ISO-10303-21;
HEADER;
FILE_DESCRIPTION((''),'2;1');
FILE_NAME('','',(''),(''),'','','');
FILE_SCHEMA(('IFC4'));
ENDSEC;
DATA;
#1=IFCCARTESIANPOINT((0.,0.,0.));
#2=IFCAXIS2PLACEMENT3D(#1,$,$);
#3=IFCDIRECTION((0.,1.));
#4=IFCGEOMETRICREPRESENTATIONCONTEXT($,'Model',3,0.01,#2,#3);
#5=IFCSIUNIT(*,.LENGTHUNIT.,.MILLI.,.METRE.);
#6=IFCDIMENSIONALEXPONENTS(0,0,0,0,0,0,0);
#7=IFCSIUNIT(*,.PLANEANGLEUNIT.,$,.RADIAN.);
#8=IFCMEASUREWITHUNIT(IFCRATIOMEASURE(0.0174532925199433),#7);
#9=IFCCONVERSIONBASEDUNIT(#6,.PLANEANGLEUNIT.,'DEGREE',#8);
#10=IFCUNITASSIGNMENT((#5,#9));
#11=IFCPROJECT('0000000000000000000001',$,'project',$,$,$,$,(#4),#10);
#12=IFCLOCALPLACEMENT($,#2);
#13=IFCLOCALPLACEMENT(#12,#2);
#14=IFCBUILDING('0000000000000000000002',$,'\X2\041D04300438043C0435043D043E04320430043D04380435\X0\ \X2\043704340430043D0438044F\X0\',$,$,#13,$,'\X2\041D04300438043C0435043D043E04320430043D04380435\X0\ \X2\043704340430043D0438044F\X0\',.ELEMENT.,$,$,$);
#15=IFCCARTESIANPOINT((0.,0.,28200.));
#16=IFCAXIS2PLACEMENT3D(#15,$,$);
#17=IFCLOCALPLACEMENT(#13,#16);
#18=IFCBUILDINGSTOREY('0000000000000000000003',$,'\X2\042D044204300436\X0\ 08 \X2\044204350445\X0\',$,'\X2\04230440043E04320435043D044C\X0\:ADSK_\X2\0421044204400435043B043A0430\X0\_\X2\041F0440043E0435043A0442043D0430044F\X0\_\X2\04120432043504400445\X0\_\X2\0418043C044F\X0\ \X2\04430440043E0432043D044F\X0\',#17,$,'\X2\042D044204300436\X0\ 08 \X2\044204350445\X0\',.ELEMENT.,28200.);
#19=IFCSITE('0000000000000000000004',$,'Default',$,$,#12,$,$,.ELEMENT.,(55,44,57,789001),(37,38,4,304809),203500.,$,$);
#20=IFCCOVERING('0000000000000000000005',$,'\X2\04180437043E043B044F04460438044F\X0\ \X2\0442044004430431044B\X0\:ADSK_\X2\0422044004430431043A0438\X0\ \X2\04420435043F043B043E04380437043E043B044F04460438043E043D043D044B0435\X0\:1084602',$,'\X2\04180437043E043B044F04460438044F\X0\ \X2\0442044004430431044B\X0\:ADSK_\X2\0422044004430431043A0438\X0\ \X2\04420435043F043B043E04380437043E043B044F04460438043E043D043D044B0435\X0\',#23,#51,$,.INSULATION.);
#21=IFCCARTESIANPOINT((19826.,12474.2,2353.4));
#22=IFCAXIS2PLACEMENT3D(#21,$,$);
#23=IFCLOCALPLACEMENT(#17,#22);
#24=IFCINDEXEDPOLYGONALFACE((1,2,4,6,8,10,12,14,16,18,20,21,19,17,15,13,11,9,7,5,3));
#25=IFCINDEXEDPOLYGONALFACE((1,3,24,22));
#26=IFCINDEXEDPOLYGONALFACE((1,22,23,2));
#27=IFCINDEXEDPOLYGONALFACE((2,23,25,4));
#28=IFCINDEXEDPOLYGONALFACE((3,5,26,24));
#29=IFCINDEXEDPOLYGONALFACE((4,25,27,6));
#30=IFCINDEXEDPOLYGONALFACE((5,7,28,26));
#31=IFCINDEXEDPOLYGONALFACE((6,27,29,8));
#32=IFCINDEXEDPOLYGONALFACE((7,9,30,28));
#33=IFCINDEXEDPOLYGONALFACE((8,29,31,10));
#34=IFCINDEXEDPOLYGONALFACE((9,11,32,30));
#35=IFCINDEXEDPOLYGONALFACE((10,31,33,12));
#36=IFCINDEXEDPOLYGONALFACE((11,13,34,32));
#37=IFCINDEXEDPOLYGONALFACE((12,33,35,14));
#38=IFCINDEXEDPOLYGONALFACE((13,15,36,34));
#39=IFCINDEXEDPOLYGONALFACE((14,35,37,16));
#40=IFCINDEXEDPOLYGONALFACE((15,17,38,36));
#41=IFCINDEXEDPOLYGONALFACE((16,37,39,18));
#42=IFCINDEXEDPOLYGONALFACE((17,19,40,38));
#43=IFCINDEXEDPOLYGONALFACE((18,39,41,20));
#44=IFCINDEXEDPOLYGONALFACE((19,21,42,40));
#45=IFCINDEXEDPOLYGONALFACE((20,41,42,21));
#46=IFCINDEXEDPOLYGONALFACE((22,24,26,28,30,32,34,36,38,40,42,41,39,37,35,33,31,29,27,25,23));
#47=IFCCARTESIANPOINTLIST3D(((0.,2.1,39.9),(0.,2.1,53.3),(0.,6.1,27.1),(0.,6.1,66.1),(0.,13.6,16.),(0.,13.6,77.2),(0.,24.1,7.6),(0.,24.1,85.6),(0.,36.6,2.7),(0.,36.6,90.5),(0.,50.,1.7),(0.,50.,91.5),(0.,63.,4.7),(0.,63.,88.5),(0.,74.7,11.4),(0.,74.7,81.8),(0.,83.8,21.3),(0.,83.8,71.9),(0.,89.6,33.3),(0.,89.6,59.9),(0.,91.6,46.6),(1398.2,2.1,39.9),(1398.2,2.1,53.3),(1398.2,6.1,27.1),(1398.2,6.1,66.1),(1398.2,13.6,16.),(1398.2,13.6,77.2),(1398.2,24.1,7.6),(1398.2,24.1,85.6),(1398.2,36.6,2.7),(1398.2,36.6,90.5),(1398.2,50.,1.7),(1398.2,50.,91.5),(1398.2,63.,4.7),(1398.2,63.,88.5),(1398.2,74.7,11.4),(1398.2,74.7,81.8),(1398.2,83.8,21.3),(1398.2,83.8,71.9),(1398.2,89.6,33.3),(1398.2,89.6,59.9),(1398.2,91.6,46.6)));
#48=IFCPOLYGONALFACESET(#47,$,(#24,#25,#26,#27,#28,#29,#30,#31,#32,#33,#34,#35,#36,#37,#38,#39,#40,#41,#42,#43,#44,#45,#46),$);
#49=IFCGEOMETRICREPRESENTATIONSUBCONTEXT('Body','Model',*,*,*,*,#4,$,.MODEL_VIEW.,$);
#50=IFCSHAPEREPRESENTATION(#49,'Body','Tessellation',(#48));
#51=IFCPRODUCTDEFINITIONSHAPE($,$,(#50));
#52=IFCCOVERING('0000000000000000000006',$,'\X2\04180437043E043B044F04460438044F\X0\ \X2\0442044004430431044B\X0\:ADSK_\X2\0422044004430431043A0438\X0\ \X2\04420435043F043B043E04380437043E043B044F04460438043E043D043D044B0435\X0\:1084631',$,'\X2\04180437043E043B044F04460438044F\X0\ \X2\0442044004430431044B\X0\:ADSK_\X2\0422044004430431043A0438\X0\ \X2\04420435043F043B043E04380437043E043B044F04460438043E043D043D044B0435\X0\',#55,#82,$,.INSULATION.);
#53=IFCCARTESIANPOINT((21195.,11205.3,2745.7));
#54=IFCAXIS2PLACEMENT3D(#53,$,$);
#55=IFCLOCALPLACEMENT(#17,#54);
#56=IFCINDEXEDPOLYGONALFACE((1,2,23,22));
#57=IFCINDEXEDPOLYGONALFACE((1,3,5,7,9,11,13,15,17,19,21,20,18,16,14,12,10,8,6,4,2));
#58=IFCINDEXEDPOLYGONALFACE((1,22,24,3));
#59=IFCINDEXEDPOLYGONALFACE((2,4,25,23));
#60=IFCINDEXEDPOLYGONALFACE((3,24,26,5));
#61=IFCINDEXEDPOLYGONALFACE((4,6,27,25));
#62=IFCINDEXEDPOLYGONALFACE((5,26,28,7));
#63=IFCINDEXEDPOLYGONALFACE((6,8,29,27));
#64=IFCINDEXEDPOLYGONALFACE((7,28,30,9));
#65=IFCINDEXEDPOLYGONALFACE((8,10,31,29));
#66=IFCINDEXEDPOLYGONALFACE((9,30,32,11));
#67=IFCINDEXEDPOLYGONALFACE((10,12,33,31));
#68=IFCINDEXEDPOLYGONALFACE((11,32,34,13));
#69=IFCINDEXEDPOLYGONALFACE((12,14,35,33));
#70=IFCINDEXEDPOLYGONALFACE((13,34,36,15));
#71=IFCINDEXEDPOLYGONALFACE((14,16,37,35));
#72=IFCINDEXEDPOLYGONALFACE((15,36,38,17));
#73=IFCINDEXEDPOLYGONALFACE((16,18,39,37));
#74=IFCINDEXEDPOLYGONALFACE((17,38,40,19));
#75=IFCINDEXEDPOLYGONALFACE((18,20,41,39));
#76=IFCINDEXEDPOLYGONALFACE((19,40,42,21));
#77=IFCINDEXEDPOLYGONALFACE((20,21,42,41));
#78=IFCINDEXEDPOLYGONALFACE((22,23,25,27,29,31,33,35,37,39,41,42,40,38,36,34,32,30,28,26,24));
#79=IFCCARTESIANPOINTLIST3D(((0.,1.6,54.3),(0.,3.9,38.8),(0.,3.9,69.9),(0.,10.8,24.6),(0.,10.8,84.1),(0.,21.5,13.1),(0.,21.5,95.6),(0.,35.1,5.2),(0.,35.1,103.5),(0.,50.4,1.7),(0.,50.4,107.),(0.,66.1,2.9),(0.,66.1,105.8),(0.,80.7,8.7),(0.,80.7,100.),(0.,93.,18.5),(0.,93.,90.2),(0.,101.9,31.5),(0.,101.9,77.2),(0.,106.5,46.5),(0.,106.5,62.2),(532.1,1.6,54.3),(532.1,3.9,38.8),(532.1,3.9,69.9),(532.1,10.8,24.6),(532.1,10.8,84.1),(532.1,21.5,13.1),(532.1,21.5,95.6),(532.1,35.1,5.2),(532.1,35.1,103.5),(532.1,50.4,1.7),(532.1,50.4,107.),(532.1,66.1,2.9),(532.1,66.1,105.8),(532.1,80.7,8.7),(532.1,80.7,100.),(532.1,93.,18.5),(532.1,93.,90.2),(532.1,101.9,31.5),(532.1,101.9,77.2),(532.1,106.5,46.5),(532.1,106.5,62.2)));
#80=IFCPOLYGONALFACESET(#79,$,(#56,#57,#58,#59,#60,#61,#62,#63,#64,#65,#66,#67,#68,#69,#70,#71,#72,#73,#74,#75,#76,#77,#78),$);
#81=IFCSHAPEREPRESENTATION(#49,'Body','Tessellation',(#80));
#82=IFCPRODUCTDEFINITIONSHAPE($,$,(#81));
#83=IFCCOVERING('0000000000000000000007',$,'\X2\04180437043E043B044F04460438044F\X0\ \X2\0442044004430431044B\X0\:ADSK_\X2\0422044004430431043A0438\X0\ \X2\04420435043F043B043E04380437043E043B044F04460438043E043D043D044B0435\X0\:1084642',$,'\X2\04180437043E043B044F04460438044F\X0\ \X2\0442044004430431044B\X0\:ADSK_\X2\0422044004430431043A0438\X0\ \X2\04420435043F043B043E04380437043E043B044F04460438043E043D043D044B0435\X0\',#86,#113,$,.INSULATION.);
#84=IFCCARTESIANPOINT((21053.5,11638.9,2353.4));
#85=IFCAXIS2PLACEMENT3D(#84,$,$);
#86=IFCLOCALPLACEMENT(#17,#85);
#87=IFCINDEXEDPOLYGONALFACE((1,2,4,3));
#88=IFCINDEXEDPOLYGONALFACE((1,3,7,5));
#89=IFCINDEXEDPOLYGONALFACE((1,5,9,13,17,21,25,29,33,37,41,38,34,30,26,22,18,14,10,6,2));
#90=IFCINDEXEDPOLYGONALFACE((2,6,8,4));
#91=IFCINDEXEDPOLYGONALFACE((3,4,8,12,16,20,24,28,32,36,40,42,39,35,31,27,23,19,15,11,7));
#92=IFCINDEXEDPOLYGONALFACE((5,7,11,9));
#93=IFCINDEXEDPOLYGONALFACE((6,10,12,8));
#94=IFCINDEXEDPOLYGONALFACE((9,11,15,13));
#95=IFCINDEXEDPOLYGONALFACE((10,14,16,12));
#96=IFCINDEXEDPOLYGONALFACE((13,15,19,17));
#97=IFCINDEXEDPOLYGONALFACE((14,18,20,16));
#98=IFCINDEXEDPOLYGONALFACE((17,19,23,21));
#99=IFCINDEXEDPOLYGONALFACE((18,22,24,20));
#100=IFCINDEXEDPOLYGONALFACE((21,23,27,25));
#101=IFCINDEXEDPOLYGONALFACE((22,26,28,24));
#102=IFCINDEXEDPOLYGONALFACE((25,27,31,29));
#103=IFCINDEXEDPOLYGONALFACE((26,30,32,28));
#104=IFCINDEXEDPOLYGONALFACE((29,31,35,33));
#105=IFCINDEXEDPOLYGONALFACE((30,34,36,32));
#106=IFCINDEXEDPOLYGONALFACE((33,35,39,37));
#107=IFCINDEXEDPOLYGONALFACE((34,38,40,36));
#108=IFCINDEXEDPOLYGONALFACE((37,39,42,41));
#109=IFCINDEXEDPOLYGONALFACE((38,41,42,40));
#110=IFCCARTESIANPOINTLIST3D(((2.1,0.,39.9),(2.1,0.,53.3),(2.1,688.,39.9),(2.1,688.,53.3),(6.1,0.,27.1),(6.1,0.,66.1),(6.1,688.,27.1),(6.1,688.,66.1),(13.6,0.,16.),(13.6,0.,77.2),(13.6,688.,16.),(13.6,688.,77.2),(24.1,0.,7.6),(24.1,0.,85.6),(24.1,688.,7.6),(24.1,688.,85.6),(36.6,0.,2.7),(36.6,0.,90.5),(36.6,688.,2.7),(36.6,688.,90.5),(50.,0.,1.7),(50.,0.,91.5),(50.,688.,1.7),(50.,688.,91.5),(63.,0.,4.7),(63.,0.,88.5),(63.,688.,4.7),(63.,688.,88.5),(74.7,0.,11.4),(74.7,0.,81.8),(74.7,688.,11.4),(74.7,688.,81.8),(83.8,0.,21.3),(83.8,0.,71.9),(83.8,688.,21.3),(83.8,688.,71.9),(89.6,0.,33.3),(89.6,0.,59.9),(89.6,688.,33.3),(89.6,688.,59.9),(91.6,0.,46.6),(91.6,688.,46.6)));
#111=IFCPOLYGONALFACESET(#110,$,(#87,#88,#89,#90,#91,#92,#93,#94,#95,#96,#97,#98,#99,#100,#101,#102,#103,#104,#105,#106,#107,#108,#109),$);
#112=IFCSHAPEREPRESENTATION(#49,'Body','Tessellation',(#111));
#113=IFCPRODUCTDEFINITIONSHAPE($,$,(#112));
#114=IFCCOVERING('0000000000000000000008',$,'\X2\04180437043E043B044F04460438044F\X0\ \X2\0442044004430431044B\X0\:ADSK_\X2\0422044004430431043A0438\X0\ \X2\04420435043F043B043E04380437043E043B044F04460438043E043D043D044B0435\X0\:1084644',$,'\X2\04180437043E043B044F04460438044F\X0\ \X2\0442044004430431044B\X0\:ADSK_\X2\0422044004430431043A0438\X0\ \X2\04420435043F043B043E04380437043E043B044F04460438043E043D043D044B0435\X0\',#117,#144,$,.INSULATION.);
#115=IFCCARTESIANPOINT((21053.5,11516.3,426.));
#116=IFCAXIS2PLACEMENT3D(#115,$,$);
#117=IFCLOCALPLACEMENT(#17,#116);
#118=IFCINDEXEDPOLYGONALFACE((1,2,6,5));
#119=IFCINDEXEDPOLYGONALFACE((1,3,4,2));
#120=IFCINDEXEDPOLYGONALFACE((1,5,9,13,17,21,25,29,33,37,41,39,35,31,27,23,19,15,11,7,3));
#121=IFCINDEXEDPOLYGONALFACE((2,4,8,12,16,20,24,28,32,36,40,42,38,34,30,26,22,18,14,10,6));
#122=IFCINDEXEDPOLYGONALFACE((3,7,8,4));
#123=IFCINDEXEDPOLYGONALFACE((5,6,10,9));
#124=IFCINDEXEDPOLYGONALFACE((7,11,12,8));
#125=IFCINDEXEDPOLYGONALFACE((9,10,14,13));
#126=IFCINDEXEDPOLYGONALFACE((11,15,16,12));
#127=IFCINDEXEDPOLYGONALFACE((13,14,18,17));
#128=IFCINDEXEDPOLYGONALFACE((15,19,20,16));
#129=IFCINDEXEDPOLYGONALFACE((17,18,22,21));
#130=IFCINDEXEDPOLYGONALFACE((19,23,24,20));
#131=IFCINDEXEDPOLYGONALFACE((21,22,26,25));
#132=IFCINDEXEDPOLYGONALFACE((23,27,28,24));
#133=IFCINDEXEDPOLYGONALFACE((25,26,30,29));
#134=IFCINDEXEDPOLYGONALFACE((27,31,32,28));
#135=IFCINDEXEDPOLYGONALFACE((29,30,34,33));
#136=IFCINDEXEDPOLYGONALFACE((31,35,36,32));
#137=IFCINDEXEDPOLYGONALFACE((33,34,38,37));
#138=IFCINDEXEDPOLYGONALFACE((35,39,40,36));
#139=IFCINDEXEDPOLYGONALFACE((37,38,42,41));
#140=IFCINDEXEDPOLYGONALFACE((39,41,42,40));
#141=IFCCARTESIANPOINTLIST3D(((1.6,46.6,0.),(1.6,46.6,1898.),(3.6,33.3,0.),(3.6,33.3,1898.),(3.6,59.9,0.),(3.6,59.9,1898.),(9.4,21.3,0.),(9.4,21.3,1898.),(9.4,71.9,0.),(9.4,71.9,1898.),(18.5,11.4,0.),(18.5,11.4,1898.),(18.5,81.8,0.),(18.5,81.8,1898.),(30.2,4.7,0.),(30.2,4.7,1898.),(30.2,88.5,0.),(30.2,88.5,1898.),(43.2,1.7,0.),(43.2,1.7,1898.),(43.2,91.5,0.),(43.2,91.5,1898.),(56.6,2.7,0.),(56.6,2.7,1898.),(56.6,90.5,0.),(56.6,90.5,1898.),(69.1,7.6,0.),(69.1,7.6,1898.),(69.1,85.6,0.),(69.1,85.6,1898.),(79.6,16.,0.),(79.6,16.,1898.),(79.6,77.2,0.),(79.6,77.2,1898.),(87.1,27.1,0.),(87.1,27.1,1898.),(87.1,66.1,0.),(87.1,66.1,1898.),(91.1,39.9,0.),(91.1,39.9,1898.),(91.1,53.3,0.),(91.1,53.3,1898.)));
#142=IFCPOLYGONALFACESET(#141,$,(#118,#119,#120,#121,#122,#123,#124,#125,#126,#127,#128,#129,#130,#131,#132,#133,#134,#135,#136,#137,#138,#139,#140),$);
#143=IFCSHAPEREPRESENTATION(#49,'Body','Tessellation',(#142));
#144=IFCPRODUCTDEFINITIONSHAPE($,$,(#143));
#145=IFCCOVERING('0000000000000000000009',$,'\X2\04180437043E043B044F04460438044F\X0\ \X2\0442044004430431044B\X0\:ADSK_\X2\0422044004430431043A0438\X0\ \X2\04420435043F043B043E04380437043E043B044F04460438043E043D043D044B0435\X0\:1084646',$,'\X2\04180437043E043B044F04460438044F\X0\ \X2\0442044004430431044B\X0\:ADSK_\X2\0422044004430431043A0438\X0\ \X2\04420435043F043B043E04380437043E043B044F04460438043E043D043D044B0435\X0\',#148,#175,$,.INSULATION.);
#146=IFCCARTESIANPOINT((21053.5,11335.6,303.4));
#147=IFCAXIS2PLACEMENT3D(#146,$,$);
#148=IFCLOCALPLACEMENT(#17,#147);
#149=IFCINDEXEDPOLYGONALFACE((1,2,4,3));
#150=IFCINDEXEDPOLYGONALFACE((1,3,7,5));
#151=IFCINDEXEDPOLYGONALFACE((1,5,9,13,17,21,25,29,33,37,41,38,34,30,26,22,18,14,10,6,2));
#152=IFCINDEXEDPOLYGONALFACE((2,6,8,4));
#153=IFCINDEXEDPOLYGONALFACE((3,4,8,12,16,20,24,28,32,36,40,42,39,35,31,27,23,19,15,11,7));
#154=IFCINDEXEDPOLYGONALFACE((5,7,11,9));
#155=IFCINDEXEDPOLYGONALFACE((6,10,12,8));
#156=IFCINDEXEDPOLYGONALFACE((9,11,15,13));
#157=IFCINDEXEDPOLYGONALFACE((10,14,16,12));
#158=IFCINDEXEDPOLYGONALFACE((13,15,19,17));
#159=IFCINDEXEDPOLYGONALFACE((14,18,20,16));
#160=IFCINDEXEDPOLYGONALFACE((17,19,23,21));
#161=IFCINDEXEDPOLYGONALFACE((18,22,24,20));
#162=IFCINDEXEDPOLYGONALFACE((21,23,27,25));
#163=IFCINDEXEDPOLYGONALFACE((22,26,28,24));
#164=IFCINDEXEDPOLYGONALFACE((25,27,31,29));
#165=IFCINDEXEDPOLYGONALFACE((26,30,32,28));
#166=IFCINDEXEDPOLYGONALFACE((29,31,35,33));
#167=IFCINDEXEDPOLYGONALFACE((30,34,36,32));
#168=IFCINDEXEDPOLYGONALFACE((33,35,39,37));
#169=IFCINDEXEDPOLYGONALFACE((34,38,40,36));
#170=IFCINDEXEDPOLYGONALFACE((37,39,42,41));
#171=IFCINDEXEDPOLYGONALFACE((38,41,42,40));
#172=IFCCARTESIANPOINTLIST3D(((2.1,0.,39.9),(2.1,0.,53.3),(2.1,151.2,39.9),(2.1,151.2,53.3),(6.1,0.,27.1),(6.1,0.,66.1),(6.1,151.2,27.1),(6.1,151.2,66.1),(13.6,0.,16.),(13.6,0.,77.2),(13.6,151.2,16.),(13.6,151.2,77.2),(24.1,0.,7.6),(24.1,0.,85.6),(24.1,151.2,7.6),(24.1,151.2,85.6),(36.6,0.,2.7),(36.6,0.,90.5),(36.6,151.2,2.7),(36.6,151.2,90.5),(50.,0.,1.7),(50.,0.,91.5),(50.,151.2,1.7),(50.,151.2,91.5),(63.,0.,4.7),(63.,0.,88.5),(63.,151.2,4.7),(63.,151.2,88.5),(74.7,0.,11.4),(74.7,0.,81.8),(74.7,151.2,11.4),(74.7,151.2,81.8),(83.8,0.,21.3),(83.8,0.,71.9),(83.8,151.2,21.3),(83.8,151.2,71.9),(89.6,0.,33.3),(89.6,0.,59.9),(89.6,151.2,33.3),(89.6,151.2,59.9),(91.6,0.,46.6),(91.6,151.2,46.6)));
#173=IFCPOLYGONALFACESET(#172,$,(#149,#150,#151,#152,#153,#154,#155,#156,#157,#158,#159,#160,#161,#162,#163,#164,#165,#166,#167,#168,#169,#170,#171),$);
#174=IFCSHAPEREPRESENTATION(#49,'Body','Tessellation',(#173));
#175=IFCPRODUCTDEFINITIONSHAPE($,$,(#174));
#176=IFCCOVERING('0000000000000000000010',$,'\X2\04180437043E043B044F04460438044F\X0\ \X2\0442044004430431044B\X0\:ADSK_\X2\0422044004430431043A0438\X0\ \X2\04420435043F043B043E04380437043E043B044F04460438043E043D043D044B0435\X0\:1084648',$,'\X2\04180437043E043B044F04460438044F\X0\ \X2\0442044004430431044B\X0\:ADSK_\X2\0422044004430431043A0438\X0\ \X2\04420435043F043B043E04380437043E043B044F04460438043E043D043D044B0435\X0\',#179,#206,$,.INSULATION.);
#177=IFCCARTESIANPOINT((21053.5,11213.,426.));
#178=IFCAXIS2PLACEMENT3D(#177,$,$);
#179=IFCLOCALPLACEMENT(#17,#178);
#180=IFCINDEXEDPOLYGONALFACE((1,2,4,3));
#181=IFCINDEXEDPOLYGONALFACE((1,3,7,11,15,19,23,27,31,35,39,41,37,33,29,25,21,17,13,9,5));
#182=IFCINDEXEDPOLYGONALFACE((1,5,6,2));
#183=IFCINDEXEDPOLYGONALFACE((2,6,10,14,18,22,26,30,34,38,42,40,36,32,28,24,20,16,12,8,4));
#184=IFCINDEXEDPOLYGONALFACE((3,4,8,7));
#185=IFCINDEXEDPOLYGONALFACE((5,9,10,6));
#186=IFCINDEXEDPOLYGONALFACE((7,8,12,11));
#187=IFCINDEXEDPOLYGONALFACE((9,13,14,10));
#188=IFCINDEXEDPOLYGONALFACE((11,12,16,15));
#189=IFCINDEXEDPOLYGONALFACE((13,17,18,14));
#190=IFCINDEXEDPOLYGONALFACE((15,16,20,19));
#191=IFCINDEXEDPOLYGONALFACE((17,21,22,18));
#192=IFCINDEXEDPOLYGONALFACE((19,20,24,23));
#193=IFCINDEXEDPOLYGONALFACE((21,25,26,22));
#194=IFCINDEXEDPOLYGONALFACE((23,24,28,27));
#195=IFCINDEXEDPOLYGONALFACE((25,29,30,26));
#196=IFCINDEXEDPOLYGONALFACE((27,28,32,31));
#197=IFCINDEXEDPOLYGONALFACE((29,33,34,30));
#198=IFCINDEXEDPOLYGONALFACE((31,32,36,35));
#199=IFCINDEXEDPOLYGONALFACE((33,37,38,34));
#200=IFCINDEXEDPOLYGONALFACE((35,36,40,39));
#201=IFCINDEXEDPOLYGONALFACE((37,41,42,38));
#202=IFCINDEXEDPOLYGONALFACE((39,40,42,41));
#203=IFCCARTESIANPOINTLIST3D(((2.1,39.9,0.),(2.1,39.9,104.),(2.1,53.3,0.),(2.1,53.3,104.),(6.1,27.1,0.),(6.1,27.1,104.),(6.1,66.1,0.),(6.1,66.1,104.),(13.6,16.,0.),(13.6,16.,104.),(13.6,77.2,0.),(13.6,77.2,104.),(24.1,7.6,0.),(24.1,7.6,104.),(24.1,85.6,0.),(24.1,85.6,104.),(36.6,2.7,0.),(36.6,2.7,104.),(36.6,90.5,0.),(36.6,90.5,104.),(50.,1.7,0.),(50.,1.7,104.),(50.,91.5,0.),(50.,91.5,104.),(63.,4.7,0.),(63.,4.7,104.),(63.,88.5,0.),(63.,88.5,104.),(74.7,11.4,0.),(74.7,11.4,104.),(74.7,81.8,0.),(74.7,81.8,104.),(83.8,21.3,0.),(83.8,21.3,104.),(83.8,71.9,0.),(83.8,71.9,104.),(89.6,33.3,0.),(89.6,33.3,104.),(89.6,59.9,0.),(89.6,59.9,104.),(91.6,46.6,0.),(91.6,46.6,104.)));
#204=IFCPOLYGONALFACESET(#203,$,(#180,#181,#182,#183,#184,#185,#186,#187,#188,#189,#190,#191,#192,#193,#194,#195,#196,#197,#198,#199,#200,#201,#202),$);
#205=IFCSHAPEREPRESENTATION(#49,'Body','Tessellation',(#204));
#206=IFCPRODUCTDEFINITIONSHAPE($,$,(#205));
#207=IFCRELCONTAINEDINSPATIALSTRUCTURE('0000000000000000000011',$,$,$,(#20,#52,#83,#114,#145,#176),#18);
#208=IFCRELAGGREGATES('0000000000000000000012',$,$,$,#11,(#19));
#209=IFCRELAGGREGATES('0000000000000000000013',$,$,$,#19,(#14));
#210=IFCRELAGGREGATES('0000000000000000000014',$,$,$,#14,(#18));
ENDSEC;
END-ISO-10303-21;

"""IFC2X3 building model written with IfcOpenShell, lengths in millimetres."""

from ifc_helpers import new_model, entity, si_unit, converted_unit, direction, frame, origin, origin_2d_with_axis, place, context, subcontext, project, spatial, circle, extrude, element, save


model = new_model("IFC2X3")

# Units and contexts
model_context = context("Model", 3, precision=0.01, world=origin(), true_north=direction((0.0, 1.0)))
body_context = subcontext(model_context, "Body", "Model", "MODEL_VIEW")
ifc_project = project(units=[si_unit("LENGTHUNIT", "METRE", prefix="MILLI"), converted_unit("PLANEANGLEUNIT", "DEGREE", entity("IfcRatioMeasure", 0.0174532925199433), si_unit("PLANEANGLEUNIT", "RADIAN"), dimensions=[0, 0, 0, 0, 0, 0, 0])], contexts=[model_context])

# Site, building, storey
site_placement = place(None, origin())
site = spatial("IfcSite", under=ifc_project, at=site_placement, Name="Default", CompositionType="ELEMENT", RefLatitude=(55, 44, 57, 789001), RefLongitude=(37, 38, 4, 304809), RefElevation=203500.0)
building_placement = place(site_placement, origin())
building = spatial("IfcBuilding", under=site, at=building_placement, Name="Наименование здания", LongName="Наименование здания", CompositionType="ELEMENT")
storey_placement = place(building_placement, frame((0.0, 0.0, 28200.0)))
storey = spatial("IfcBuildingStorey", under=building, at=storey_placement, Name="Этаж 08 тех", ObjectType="Уровень:ADSK_Стрелка_Проектная_Вверх_Имя уровня", LongName="Этаж 08 тех", CompositionType="ELEMENT", Elevation=28200.0)

# Coverings
covering_1_placement = place(storey_placement, frame((19826.0, 12474.2, 2353.4)))
element("IfcCovering", 1, at=covering_1_placement, inside=storey, Name="Изоляция трубы:ADSK_Трубки теплоизоляционные:1084602", ObjectType="Изоляция трубы:ADSK_Трубки теплоизоляционные", PredefinedType="INSULATION", context=body_context, shape_type="SweptSolid", body=[
    extrude(circle(Radius=45.0, at=origin_2d_with_axis()), frame((0.0, 46.6, 46.6), z_axis=(1.0, 0.0, 0.0), x_axis=(0.0, 1.0, 0.0)), (0.0, 0.0, 1.0), 1398.2),
])
covering_2_placement = place(storey_placement, frame((21195.0, 11205.3, 2745.7)))
element("IfcCovering", 2, at=covering_2_placement, inside=storey, Name="Изоляция трубы:ADSK_Трубки теплоизоляционные:1084631", ObjectType="Изоляция трубы:ADSK_Трубки теплоизоляционные", PredefinedType="INSULATION", context=body_context, shape_type="SweptSolid", body=[
    extrude(circle(Radius=52.8, at=origin_2d_with_axis()), frame((0.0, 54.4, 54.4), z_axis=(1.0, 0.0, 0.0), x_axis=(0.0, -1.0, 0.0)), (0.0, 0.0, 1.0), 532.1),
])
covering_3_placement = place(storey_placement, frame((21053.5, 11638.9, 2353.4)))
element("IfcCovering", 3, at=covering_3_placement, inside=storey, Name="Изоляция трубы:ADSK_Трубки теплоизоляционные:1084642", ObjectType="Изоляция трубы:ADSK_Трубки теплоизоляционные", PredefinedType="INSULATION", context=body_context, shape_type="SweptSolid", body=[
    extrude(circle(Radius=45.0, at=origin_2d_with_axis()), frame((46.6, 0.0, 46.6), z_axis=(0.0, 1.0, 0.0), x_axis=(1.0, 0.0, 0.0)), (0.0, 0.0, 1.0), 688.0),
])
covering_4_placement = place(storey_placement, frame((21053.5, 11516.3, 426.0)))
element("IfcCovering", 4, at=covering_4_placement, inside=storey, Name="Изоляция трубы:ADSK_Трубки теплоизоляционные:1084644", ObjectType="Изоляция трубы:ADSK_Трубки теплоизоляционные", PredefinedType="INSULATION", context=body_context, shape_type="SweptSolid", body=[
    extrude(circle(Radius=45.0, at=origin_2d_with_axis()), frame((46.6, 46.6, 0.0), z_axis=(0.0, 0.0, 1.0), x_axis=(-1.0, 0.0, 0.0)), (0.0, 0.0, 1.0), 1898.0),
])
covering_5_placement = place(storey_placement, frame((21053.5, 11335.6, 303.4)))
element("IfcCovering", 5, at=covering_5_placement, inside=storey, Name="Изоляция трубы:ADSK_Трубки теплоизоляционные:1084646", ObjectType="Изоляция трубы:ADSK_Трубки теплоизоляционные", PredefinedType="INSULATION", context=body_context, shape_type="SweptSolid", body=[
    extrude(circle(Radius=45.0, at=origin_2d_with_axis()), frame((46.6, 0.0, 46.6), z_axis=(0.0, 1.0, 0.0), x_axis=(1.0, 0.0, 0.0)), (0.0, 0.0, 1.0), 151.2),
])
covering_6_placement = place(storey_placement, frame((21053.5, 11213.0, 426.0)))
element("IfcCovering", 6, at=covering_6_placement, inside=storey, Name="Изоляция трубы:ADSK_Трубки теплоизоляционные:1084648", ObjectType="Изоляция трубы:ADSK_Трубки теплоизоляционные", PredefinedType="INSULATION", context=body_context, shape_type="SweptSolid", body=[
    extrude(circle(Radius=45.0, at=origin_2d_with_axis()), frame((46.6, 46.6, 0.0)), (0.0, 0.0, 1.0), 104.0),
])

save(model, "model.ifc")
